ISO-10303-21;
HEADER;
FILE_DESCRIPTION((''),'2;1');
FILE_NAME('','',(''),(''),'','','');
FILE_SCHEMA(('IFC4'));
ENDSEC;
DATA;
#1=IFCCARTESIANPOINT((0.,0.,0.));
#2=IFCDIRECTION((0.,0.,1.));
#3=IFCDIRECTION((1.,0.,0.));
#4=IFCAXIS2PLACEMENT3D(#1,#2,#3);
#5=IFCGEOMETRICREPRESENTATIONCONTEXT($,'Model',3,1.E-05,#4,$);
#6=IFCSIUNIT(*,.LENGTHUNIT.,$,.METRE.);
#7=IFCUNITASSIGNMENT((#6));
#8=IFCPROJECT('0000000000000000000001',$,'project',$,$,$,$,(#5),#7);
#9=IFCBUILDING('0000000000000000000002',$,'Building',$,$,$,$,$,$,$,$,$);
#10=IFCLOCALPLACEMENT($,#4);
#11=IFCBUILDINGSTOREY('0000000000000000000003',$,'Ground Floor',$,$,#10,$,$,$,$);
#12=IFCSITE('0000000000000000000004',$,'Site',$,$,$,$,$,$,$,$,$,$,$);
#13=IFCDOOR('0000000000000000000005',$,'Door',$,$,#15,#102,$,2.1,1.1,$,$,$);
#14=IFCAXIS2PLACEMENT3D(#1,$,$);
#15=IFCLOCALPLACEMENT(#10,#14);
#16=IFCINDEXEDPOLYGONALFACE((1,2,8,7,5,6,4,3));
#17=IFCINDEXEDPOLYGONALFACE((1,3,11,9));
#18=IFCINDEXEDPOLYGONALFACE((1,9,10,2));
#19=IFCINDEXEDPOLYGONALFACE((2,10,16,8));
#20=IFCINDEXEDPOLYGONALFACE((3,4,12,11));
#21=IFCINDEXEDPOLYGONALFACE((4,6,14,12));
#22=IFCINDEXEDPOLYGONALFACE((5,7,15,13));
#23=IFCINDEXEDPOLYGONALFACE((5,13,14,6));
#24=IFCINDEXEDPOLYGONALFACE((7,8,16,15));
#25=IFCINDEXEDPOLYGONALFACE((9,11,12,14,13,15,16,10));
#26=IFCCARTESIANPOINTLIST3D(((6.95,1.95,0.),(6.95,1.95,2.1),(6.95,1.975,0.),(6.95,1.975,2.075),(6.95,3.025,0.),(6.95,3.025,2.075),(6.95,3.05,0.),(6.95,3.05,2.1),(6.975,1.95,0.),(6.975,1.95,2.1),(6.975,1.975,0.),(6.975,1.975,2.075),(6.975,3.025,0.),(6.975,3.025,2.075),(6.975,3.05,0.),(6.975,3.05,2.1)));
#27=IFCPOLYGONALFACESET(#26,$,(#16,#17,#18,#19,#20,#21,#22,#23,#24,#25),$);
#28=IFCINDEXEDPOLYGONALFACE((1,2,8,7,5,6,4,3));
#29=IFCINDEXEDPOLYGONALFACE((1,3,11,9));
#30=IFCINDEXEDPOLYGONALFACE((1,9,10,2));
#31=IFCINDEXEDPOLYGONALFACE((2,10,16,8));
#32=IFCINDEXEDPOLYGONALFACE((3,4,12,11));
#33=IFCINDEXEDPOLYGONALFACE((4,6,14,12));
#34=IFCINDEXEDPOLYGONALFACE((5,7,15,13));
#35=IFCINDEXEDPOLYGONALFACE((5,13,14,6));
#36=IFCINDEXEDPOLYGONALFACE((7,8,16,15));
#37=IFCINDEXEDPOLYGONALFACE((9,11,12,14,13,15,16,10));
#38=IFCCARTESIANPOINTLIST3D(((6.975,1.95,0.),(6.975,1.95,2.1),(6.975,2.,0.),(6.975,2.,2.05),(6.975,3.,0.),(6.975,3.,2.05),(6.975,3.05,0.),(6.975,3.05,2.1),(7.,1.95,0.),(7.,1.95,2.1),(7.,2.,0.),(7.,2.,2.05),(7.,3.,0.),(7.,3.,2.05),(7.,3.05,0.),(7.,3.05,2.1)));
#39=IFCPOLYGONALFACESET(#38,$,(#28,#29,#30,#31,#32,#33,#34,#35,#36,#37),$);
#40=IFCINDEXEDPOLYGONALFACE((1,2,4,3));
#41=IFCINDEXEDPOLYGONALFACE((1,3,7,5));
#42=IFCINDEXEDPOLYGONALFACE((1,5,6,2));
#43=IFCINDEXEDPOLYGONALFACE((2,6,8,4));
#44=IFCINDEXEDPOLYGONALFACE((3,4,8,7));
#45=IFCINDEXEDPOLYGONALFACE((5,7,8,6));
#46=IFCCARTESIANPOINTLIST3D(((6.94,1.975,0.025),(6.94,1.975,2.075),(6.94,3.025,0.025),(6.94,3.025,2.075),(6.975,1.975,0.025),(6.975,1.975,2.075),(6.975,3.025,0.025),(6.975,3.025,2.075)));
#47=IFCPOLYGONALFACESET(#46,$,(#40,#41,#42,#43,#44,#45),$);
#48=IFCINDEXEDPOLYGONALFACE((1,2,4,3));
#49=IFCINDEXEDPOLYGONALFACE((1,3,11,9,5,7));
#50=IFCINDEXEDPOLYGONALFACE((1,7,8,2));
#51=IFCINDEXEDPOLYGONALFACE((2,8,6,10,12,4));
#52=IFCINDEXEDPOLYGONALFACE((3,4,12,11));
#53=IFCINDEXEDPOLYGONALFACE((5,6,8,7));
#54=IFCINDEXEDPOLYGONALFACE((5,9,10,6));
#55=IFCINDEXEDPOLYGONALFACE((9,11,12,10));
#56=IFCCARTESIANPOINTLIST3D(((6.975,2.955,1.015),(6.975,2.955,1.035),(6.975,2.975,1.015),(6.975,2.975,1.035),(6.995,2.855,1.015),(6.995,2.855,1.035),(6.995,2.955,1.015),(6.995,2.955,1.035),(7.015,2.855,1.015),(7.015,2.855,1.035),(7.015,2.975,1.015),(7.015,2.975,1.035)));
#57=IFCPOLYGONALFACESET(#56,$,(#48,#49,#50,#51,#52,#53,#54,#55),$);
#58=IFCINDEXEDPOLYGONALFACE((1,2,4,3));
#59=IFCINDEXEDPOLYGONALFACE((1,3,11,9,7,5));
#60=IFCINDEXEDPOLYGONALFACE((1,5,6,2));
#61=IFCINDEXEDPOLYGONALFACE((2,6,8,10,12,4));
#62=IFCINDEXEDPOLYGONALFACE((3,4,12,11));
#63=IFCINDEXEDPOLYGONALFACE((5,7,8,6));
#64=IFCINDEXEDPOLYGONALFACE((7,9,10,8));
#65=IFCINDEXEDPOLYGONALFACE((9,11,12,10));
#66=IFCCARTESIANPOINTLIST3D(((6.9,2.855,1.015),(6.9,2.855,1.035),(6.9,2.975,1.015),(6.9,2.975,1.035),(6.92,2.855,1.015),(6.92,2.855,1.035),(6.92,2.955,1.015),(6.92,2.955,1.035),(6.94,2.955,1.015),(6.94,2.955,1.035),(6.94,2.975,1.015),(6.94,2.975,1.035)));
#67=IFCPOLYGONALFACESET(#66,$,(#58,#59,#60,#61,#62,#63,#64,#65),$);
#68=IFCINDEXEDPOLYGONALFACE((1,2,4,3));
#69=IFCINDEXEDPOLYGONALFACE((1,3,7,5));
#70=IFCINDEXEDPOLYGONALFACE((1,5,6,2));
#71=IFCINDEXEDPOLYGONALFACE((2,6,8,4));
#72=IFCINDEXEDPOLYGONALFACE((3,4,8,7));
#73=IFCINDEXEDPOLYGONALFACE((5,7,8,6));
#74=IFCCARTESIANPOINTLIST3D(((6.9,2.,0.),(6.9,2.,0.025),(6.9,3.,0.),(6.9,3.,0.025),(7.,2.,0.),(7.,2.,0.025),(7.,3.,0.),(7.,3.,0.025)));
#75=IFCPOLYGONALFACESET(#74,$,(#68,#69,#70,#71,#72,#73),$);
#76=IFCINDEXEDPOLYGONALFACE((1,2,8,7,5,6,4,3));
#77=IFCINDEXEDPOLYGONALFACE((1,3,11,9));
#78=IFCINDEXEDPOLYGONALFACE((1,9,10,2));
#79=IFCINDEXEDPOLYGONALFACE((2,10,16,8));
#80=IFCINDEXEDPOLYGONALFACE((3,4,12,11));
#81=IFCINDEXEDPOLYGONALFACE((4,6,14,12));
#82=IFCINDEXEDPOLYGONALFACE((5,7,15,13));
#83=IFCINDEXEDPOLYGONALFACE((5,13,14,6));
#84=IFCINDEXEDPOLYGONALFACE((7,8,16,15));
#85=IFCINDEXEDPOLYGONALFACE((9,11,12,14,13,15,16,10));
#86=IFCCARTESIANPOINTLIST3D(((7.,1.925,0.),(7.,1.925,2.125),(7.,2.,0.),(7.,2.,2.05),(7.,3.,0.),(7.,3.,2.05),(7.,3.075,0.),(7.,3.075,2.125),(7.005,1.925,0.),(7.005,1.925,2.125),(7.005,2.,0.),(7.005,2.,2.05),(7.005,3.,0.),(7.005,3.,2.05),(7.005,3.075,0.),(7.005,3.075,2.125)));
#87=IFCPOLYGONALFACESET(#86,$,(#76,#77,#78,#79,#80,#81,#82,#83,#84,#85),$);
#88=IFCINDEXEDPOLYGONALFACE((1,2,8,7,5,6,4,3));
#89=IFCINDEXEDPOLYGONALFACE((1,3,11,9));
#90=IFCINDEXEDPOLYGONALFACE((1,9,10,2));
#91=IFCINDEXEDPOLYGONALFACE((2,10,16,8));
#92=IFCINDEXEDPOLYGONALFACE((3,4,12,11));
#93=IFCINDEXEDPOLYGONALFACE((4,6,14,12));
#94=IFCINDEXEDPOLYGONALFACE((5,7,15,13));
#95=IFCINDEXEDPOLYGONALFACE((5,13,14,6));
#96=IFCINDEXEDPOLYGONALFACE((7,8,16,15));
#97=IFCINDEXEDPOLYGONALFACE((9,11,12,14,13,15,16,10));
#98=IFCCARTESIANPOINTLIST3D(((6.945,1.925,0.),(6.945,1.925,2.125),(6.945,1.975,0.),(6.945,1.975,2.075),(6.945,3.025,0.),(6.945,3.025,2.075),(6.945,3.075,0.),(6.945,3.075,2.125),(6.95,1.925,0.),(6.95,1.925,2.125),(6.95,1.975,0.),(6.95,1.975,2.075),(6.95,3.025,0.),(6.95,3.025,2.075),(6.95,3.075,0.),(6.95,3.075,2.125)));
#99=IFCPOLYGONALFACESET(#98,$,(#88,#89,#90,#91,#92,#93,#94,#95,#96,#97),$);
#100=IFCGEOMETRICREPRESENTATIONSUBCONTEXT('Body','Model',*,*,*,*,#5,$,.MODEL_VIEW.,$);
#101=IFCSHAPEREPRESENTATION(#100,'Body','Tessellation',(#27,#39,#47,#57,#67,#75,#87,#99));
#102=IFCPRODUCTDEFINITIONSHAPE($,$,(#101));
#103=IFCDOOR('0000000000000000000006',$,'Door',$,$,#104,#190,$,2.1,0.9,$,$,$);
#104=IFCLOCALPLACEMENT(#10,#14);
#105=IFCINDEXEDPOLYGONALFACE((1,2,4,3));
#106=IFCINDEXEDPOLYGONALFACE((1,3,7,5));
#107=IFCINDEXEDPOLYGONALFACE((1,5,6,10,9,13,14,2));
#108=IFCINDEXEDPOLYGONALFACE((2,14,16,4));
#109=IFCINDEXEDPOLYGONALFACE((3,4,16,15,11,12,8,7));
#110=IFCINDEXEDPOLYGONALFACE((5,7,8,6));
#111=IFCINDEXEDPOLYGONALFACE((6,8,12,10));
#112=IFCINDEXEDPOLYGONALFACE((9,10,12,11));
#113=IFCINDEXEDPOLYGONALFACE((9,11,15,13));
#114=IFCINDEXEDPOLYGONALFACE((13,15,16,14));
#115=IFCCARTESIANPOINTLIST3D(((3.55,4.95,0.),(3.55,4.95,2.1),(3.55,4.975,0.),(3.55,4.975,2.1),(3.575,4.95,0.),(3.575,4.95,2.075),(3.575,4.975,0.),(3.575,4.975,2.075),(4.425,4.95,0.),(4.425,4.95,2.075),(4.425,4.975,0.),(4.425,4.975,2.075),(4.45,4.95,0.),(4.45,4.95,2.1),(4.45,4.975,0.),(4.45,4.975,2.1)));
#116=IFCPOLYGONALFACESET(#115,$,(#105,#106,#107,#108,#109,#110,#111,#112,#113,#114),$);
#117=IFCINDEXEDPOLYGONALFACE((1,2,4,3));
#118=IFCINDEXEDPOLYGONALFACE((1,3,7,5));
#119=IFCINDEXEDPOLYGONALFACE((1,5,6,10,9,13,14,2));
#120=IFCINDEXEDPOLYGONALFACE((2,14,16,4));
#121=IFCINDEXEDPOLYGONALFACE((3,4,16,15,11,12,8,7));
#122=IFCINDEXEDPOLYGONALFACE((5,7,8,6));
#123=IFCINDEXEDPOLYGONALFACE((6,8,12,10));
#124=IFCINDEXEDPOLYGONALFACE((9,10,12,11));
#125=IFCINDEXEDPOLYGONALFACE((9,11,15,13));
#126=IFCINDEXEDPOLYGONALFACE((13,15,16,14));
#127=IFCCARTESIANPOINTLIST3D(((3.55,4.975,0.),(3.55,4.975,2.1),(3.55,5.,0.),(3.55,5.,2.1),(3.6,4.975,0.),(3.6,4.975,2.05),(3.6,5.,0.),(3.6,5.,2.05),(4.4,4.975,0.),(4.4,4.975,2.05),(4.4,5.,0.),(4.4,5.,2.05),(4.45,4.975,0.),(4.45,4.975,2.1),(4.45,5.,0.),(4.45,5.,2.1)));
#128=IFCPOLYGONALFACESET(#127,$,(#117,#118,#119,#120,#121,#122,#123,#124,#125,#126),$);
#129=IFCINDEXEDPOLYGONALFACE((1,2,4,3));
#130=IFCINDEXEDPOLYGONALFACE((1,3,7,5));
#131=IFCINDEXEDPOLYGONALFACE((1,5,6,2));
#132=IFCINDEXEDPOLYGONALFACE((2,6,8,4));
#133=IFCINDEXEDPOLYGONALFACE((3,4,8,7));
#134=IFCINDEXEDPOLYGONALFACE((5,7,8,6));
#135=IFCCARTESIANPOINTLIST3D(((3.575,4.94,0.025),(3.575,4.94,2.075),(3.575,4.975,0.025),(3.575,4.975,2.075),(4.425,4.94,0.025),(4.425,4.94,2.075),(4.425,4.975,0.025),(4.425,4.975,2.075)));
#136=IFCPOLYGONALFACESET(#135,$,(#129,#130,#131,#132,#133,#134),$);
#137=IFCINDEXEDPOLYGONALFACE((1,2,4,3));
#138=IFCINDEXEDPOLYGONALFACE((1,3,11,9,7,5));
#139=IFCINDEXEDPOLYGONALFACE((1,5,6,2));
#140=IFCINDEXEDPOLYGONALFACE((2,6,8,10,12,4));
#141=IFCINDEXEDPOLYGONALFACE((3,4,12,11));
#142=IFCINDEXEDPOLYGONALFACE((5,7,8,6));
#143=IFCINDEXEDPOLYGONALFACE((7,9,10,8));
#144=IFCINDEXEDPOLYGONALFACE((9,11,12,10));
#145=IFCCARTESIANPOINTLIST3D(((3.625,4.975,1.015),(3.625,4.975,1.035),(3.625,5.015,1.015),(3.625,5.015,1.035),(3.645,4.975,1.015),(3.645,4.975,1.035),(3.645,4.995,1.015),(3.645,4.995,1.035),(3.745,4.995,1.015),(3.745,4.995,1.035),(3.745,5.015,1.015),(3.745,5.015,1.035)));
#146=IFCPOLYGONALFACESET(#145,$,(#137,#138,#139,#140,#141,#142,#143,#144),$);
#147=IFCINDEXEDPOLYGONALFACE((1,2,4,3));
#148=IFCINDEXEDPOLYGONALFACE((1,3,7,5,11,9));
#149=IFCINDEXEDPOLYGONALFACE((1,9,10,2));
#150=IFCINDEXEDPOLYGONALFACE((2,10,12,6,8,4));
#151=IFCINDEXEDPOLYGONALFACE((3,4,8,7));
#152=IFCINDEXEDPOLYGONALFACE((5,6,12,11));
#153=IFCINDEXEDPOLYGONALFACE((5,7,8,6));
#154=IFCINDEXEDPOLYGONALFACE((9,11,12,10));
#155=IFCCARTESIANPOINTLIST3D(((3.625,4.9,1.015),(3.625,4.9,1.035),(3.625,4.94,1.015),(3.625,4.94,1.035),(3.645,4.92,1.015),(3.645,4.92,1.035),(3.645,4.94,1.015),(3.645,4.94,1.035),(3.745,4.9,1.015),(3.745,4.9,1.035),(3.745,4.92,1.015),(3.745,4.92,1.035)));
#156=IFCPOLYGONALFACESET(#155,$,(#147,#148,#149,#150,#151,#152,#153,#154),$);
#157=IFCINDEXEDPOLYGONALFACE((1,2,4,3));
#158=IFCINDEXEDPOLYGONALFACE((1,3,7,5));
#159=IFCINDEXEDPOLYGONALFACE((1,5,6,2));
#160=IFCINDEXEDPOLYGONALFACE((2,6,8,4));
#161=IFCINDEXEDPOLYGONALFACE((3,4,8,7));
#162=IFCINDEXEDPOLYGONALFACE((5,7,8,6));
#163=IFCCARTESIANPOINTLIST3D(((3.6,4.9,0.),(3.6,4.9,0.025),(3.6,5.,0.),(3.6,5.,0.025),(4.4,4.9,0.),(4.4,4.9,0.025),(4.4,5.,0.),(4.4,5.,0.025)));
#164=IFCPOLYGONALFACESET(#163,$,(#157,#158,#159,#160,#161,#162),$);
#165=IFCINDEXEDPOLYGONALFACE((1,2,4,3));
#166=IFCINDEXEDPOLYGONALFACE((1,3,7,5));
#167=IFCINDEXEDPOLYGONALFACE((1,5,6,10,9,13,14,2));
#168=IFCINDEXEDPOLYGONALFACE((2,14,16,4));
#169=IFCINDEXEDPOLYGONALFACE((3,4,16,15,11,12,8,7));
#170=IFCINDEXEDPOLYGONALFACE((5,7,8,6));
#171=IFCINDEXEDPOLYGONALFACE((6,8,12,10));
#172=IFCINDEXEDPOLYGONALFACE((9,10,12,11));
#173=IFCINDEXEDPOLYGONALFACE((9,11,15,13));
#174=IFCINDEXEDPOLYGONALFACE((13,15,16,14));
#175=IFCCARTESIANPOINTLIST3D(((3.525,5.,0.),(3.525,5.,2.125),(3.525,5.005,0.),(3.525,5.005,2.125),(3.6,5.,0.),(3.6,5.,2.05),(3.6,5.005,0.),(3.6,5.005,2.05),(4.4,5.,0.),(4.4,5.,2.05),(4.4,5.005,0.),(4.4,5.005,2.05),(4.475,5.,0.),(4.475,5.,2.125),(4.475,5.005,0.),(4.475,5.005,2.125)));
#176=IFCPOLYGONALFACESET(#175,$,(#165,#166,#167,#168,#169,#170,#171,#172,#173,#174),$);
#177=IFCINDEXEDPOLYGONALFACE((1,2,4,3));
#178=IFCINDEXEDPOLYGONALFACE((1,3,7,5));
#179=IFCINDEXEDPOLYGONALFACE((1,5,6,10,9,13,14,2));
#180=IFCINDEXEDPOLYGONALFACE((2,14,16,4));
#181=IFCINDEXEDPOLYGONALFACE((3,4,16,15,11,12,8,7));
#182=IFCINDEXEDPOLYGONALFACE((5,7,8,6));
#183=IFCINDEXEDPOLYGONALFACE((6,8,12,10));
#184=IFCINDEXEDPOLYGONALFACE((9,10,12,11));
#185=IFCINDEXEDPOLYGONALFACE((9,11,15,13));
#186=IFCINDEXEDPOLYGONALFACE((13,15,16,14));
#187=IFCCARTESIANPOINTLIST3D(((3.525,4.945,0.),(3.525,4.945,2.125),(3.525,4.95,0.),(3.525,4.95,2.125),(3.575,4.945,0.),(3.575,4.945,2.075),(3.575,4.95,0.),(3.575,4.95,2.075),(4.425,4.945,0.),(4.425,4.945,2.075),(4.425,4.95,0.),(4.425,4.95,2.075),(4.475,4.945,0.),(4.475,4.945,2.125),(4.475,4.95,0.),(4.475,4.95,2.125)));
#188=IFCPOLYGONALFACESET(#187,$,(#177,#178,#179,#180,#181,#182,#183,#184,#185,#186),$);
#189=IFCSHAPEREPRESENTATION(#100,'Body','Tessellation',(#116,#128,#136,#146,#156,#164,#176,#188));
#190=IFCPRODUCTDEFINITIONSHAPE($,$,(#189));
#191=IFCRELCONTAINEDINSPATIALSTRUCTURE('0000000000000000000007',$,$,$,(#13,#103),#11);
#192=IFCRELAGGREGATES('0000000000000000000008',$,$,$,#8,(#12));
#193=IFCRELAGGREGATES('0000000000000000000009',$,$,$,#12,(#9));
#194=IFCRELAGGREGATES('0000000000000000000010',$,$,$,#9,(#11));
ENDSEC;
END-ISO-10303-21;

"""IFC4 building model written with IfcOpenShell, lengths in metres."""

from ifc_helpers import new_model, si_unit, frame, origin_with_axes, place, context, subcontext, project, spatial, line, indexed_curve, outline, extrude, element, save


model = new_model("IFC4")

# Units and contexts
model_context = context("Model", 3, precision=1e-05, world=origin_with_axes())
body_context = subcontext(model_context, "Body", "Model", "MODEL_VIEW")
ifc_project = project(units=[si_unit("LENGTHUNIT", "METRE")], contexts=[model_context])

# Site, building, storey
site = spatial("IfcSite", under=ifc_project, Name="Site")
building = spatial("IfcBuilding", under=site, Name="Building")
storey_placement = place(None, origin_with_axes())
storey = spatial("IfcBuildingStorey", under=building, at=storey_placement, Name="Ground Floor")

# Doors
door_1_placement = place(storey_placement, frame((7.0, 1.95, 0.0), z_axis=(0.0, 0.0, 1.0), x_axis=(0.0, 1.0, 0.0)))
element("IfcDoor", 1, at=door_1_placement, inside=storey, Name="Door", OverallHeight=2.1, OverallWidth=1.1, context=body_context, shape_type="SweptSolid", body=[
    extrude(outline(indexed_curve([(0.0, 0.0), (0.0, 2.1), (1.1, 2.1), (1.1, 0.0), (1.075, 0.0), (1.075, 2.075), (0.025, 2.075), (0.025, 0.0)], segments=[line(1, 2, 3, 4, 5, 6, 7, 8, 1)])), frame((0.0, 0.025, 0.0), z_axis=(0.0, -1.0, 0.0), x_axis=(1.0, 0.0, 0.0)), (0.0, 0.0, -1.0), 0.025),
    extrude(outline(indexed_curve([(0.0, 0.0), (0.0, 2.1), (1.1, 2.1), (1.1, 0.0), (1.05, 0.0), (1.05, 2.05), (0.05, 2.05), (0.05, 0.0)], segments=[line(1, 2, 3, 4, 5, 6, 7, 8, 1)])), frame((0.0, 0.0, 0.0), z_axis=(0.0, -1.0, 0.0), x_axis=(1.0, 0.0, 0.0)), (0.0, 0.0, -1.0), 0.025),
    extrude(outline(indexed_curve([(0.0, 0.0), (1.05, 0.0), (1.05, 0.035), (0.0, 0.035)], segments=[line(1, 2, 3, 4, 1)])), frame((0.025, 0.025, 0.025), z_axis=(0.0, 0.0, 1.0), x_axis=(1.0, 0.0, 0.0)), (0.0, 0.0, 1.0), 2.05),
    extrude(outline(indexed_curve([(0.0, 0.0), (0.0, -0.04), (-0.12, -0.04), (-0.12, -0.02), (-0.02, -0.02), (-0.02, 0.0)], segments=[line(1, 2, 3, 4, 5, 6, 1)])), frame((1.025, 0.025, 1.015), z_axis=(0.0, 0.0, 1.0), x_axis=(1.0, 0.0, 0.0)), (0.0, 0.0, 1.0), 0.02),
    extrude(outline(indexed_curve([(0.0, 0.0), (0.0, 0.04), (-0.12, 0.04), (-0.12, 0.02), (-0.02, 0.02), (-0.02, 0.0)], segments=[line(1, 2, 3, 4, 5, 6, 1)])), frame((1.025, 0.06, 1.015), z_axis=(0.0, 0.0, 1.0), x_axis=(1.0, 0.0, 0.0)), (0.0, 0.0, 1.0), 0.02),
    extrude(outline(indexed_curve([(0.0, 0.0), (1.0, 0.0), (1.0, 0.1), (0.0, 0.1)], segments=[line(1, 2, 3, 4, 1)])), frame((0.05, 0.0, 0.0), z_axis=(0.0, 0.0, 1.0), x_axis=(1.0, 0.0, 0.0)), (0.0, 0.0, 1.0), 0.025),
    extrude(outline(indexed_curve([(0.0, 0.0), (0.0, 2.125), (1.15, 2.125), (1.15, 0.0), (1.075, 0.0), (1.075, 2.05), (0.075, 2.05), (0.075, 0.0)], segments=[line(1, 2, 3, 4, 5, 6, 7, 8, 1)])), frame((-0.025, -0.005, 0.0), z_axis=(0.0, -1.0, 0.0), x_axis=(1.0, 0.0, 0.0)), (0.0, 0.0, -1.0), 0.005),
    extrude(outline(indexed_curve([(0.0, 0.0), (0.0, 2.125), (1.15, 2.125), (1.15, 0.0), (1.1, 0.0), (1.1, 2.075), (0.05, 2.075), (0.05, 0.0)], segments=[line(1, 2, 3, 4, 5, 6, 7, 8, 1)])), frame((-0.025, 0.05, 0.0), z_axis=(0.0, -1.0, 0.0), x_axis=(1.0, 0.0, 0.0)), (0.0, 0.0, -1.0), 0.005),
])
door_2_placement = place(storey_placement, frame((4.45, 5.0, 0.0), z_axis=(0.0, 0.0, 1.0), x_axis=(-1.0, 0.0, 0.0)))
element("IfcDoor", 2, at=door_2_placement, inside=storey, Name="Door", OverallHeight=2.1, OverallWidth=0.9, context=body_context, shape_type="SweptSolid", body=[
    extrude(outline(indexed_curve([(0.0, 0.0), (0.0, 2.1), (0.9, 2.1), (0.9, 0.0), (0.875, 0.0), (0.875, 2.075), (0.025, 2.075), (0.025, 0.0)], segments=[line(1, 2, 3, 4, 5, 6, 7, 8, 1)])), frame((0.0, 0.025, 0.0), z_axis=(0.0, -1.0, 0.0), x_axis=(1.0, 0.0, 0.0)), (0.0, 0.0, -1.0), 0.025),
    extrude(outline(indexed_curve([(0.0, 0.0), (0.0, 2.1), (0.9, 2.1), (0.9, 0.0), (0.85, 0.0), (0.85, 2.05), (0.05, 2.05), (0.05, 0.0)], segments=[line(1, 2, 3, 4, 5, 6, 7, 8, 1)])), frame((0.0, 0.0, 0.0), z_axis=(0.0, -1.0, 0.0), x_axis=(1.0, 0.0, 0.0)), (0.0, 0.0, -1.0), 0.025),
    extrude(outline(indexed_curve([(0.0, 0.0), (0.85, 0.0), (0.85, 0.035), (0.0, 0.035)], segments=[line(1, 2, 3, 4, 1)])), frame((0.025, 0.025, 0.025), z_axis=(0.0, 0.0, 1.0), x_axis=(1.0, 0.0, 0.0)), (0.0, 0.0, 1.0), 2.05),
    extrude(outline(indexed_curve([(0.0, 0.0), (0.0, -0.04), (-0.12, -0.04), (-0.12, -0.02), (-0.02, -0.02), (-0.02, 0.0)], segments=[line(1, 2, 3, 4, 5, 6, 1)])), frame((0.825, 0.025, 1.015), z_axis=(0.0, 0.0, 1.0), x_axis=(1.0, 0.0, 0.0)), (0.0, 0.0, 1.0), 0.02),
    extrude(outline(indexed_curve([(0.0, 0.0), (0.0, 0.04), (-0.12, 0.04), (-0.12, 0.02), (-0.02, 0.02), (-0.02, 0.0)], segments=[line(1, 2, 3, 4, 5, 6, 1)])), frame((0.825, 0.06, 1.015), z_axis=(0.0, 0.0, 1.0), x_axis=(1.0, 0.0, 0.0)), (0.0, 0.0, 1.0), 0.02),
    extrude(outline(indexed_curve([(0.0, 0.0), (0.8, 0.0), (0.8, 0.1), (0.0, 0.1)], segments=[line(1, 2, 3, 4, 1)])), frame((0.05, 0.0, 0.0), z_axis=(0.0, 0.0, 1.0), x_axis=(1.0, 0.0, 0.0)), (0.0, 0.0, 1.0), 0.025),
    extrude(outline(indexed_curve([(0.0, 0.0), (0.0, 2.125), (0.95, 2.125), (0.95, 0.0), (0.875, 0.0), (0.875, 2.05), (0.075, 2.05), (0.075, 0.0)], segments=[line(1, 2, 3, 4, 5, 6, 7, 8, 1)])), frame((-0.025, -0.005, 0.0), z_axis=(0.0, -1.0, 0.0), x_axis=(1.0, 0.0, 0.0)), (0.0, 0.0, -1.0), 0.005),
    extrude(outline(indexed_curve([(0.0, 0.0), (0.0, 2.125), (0.95, 2.125), (0.95, 0.0), (0.9, 0.0), (0.9, 2.075), (0.05, 2.075), (0.05, 0.0)], segments=[line(1, 2, 3, 4, 5, 6, 7, 8, 1)])), frame((-0.025, 0.05, 0.0), z_axis=(0.0, -1.0, 0.0), x_axis=(1.0, 0.0, 0.0)), (0.0, 0.0, -1.0), 0.005),
])

save(model, "model.ifc")
